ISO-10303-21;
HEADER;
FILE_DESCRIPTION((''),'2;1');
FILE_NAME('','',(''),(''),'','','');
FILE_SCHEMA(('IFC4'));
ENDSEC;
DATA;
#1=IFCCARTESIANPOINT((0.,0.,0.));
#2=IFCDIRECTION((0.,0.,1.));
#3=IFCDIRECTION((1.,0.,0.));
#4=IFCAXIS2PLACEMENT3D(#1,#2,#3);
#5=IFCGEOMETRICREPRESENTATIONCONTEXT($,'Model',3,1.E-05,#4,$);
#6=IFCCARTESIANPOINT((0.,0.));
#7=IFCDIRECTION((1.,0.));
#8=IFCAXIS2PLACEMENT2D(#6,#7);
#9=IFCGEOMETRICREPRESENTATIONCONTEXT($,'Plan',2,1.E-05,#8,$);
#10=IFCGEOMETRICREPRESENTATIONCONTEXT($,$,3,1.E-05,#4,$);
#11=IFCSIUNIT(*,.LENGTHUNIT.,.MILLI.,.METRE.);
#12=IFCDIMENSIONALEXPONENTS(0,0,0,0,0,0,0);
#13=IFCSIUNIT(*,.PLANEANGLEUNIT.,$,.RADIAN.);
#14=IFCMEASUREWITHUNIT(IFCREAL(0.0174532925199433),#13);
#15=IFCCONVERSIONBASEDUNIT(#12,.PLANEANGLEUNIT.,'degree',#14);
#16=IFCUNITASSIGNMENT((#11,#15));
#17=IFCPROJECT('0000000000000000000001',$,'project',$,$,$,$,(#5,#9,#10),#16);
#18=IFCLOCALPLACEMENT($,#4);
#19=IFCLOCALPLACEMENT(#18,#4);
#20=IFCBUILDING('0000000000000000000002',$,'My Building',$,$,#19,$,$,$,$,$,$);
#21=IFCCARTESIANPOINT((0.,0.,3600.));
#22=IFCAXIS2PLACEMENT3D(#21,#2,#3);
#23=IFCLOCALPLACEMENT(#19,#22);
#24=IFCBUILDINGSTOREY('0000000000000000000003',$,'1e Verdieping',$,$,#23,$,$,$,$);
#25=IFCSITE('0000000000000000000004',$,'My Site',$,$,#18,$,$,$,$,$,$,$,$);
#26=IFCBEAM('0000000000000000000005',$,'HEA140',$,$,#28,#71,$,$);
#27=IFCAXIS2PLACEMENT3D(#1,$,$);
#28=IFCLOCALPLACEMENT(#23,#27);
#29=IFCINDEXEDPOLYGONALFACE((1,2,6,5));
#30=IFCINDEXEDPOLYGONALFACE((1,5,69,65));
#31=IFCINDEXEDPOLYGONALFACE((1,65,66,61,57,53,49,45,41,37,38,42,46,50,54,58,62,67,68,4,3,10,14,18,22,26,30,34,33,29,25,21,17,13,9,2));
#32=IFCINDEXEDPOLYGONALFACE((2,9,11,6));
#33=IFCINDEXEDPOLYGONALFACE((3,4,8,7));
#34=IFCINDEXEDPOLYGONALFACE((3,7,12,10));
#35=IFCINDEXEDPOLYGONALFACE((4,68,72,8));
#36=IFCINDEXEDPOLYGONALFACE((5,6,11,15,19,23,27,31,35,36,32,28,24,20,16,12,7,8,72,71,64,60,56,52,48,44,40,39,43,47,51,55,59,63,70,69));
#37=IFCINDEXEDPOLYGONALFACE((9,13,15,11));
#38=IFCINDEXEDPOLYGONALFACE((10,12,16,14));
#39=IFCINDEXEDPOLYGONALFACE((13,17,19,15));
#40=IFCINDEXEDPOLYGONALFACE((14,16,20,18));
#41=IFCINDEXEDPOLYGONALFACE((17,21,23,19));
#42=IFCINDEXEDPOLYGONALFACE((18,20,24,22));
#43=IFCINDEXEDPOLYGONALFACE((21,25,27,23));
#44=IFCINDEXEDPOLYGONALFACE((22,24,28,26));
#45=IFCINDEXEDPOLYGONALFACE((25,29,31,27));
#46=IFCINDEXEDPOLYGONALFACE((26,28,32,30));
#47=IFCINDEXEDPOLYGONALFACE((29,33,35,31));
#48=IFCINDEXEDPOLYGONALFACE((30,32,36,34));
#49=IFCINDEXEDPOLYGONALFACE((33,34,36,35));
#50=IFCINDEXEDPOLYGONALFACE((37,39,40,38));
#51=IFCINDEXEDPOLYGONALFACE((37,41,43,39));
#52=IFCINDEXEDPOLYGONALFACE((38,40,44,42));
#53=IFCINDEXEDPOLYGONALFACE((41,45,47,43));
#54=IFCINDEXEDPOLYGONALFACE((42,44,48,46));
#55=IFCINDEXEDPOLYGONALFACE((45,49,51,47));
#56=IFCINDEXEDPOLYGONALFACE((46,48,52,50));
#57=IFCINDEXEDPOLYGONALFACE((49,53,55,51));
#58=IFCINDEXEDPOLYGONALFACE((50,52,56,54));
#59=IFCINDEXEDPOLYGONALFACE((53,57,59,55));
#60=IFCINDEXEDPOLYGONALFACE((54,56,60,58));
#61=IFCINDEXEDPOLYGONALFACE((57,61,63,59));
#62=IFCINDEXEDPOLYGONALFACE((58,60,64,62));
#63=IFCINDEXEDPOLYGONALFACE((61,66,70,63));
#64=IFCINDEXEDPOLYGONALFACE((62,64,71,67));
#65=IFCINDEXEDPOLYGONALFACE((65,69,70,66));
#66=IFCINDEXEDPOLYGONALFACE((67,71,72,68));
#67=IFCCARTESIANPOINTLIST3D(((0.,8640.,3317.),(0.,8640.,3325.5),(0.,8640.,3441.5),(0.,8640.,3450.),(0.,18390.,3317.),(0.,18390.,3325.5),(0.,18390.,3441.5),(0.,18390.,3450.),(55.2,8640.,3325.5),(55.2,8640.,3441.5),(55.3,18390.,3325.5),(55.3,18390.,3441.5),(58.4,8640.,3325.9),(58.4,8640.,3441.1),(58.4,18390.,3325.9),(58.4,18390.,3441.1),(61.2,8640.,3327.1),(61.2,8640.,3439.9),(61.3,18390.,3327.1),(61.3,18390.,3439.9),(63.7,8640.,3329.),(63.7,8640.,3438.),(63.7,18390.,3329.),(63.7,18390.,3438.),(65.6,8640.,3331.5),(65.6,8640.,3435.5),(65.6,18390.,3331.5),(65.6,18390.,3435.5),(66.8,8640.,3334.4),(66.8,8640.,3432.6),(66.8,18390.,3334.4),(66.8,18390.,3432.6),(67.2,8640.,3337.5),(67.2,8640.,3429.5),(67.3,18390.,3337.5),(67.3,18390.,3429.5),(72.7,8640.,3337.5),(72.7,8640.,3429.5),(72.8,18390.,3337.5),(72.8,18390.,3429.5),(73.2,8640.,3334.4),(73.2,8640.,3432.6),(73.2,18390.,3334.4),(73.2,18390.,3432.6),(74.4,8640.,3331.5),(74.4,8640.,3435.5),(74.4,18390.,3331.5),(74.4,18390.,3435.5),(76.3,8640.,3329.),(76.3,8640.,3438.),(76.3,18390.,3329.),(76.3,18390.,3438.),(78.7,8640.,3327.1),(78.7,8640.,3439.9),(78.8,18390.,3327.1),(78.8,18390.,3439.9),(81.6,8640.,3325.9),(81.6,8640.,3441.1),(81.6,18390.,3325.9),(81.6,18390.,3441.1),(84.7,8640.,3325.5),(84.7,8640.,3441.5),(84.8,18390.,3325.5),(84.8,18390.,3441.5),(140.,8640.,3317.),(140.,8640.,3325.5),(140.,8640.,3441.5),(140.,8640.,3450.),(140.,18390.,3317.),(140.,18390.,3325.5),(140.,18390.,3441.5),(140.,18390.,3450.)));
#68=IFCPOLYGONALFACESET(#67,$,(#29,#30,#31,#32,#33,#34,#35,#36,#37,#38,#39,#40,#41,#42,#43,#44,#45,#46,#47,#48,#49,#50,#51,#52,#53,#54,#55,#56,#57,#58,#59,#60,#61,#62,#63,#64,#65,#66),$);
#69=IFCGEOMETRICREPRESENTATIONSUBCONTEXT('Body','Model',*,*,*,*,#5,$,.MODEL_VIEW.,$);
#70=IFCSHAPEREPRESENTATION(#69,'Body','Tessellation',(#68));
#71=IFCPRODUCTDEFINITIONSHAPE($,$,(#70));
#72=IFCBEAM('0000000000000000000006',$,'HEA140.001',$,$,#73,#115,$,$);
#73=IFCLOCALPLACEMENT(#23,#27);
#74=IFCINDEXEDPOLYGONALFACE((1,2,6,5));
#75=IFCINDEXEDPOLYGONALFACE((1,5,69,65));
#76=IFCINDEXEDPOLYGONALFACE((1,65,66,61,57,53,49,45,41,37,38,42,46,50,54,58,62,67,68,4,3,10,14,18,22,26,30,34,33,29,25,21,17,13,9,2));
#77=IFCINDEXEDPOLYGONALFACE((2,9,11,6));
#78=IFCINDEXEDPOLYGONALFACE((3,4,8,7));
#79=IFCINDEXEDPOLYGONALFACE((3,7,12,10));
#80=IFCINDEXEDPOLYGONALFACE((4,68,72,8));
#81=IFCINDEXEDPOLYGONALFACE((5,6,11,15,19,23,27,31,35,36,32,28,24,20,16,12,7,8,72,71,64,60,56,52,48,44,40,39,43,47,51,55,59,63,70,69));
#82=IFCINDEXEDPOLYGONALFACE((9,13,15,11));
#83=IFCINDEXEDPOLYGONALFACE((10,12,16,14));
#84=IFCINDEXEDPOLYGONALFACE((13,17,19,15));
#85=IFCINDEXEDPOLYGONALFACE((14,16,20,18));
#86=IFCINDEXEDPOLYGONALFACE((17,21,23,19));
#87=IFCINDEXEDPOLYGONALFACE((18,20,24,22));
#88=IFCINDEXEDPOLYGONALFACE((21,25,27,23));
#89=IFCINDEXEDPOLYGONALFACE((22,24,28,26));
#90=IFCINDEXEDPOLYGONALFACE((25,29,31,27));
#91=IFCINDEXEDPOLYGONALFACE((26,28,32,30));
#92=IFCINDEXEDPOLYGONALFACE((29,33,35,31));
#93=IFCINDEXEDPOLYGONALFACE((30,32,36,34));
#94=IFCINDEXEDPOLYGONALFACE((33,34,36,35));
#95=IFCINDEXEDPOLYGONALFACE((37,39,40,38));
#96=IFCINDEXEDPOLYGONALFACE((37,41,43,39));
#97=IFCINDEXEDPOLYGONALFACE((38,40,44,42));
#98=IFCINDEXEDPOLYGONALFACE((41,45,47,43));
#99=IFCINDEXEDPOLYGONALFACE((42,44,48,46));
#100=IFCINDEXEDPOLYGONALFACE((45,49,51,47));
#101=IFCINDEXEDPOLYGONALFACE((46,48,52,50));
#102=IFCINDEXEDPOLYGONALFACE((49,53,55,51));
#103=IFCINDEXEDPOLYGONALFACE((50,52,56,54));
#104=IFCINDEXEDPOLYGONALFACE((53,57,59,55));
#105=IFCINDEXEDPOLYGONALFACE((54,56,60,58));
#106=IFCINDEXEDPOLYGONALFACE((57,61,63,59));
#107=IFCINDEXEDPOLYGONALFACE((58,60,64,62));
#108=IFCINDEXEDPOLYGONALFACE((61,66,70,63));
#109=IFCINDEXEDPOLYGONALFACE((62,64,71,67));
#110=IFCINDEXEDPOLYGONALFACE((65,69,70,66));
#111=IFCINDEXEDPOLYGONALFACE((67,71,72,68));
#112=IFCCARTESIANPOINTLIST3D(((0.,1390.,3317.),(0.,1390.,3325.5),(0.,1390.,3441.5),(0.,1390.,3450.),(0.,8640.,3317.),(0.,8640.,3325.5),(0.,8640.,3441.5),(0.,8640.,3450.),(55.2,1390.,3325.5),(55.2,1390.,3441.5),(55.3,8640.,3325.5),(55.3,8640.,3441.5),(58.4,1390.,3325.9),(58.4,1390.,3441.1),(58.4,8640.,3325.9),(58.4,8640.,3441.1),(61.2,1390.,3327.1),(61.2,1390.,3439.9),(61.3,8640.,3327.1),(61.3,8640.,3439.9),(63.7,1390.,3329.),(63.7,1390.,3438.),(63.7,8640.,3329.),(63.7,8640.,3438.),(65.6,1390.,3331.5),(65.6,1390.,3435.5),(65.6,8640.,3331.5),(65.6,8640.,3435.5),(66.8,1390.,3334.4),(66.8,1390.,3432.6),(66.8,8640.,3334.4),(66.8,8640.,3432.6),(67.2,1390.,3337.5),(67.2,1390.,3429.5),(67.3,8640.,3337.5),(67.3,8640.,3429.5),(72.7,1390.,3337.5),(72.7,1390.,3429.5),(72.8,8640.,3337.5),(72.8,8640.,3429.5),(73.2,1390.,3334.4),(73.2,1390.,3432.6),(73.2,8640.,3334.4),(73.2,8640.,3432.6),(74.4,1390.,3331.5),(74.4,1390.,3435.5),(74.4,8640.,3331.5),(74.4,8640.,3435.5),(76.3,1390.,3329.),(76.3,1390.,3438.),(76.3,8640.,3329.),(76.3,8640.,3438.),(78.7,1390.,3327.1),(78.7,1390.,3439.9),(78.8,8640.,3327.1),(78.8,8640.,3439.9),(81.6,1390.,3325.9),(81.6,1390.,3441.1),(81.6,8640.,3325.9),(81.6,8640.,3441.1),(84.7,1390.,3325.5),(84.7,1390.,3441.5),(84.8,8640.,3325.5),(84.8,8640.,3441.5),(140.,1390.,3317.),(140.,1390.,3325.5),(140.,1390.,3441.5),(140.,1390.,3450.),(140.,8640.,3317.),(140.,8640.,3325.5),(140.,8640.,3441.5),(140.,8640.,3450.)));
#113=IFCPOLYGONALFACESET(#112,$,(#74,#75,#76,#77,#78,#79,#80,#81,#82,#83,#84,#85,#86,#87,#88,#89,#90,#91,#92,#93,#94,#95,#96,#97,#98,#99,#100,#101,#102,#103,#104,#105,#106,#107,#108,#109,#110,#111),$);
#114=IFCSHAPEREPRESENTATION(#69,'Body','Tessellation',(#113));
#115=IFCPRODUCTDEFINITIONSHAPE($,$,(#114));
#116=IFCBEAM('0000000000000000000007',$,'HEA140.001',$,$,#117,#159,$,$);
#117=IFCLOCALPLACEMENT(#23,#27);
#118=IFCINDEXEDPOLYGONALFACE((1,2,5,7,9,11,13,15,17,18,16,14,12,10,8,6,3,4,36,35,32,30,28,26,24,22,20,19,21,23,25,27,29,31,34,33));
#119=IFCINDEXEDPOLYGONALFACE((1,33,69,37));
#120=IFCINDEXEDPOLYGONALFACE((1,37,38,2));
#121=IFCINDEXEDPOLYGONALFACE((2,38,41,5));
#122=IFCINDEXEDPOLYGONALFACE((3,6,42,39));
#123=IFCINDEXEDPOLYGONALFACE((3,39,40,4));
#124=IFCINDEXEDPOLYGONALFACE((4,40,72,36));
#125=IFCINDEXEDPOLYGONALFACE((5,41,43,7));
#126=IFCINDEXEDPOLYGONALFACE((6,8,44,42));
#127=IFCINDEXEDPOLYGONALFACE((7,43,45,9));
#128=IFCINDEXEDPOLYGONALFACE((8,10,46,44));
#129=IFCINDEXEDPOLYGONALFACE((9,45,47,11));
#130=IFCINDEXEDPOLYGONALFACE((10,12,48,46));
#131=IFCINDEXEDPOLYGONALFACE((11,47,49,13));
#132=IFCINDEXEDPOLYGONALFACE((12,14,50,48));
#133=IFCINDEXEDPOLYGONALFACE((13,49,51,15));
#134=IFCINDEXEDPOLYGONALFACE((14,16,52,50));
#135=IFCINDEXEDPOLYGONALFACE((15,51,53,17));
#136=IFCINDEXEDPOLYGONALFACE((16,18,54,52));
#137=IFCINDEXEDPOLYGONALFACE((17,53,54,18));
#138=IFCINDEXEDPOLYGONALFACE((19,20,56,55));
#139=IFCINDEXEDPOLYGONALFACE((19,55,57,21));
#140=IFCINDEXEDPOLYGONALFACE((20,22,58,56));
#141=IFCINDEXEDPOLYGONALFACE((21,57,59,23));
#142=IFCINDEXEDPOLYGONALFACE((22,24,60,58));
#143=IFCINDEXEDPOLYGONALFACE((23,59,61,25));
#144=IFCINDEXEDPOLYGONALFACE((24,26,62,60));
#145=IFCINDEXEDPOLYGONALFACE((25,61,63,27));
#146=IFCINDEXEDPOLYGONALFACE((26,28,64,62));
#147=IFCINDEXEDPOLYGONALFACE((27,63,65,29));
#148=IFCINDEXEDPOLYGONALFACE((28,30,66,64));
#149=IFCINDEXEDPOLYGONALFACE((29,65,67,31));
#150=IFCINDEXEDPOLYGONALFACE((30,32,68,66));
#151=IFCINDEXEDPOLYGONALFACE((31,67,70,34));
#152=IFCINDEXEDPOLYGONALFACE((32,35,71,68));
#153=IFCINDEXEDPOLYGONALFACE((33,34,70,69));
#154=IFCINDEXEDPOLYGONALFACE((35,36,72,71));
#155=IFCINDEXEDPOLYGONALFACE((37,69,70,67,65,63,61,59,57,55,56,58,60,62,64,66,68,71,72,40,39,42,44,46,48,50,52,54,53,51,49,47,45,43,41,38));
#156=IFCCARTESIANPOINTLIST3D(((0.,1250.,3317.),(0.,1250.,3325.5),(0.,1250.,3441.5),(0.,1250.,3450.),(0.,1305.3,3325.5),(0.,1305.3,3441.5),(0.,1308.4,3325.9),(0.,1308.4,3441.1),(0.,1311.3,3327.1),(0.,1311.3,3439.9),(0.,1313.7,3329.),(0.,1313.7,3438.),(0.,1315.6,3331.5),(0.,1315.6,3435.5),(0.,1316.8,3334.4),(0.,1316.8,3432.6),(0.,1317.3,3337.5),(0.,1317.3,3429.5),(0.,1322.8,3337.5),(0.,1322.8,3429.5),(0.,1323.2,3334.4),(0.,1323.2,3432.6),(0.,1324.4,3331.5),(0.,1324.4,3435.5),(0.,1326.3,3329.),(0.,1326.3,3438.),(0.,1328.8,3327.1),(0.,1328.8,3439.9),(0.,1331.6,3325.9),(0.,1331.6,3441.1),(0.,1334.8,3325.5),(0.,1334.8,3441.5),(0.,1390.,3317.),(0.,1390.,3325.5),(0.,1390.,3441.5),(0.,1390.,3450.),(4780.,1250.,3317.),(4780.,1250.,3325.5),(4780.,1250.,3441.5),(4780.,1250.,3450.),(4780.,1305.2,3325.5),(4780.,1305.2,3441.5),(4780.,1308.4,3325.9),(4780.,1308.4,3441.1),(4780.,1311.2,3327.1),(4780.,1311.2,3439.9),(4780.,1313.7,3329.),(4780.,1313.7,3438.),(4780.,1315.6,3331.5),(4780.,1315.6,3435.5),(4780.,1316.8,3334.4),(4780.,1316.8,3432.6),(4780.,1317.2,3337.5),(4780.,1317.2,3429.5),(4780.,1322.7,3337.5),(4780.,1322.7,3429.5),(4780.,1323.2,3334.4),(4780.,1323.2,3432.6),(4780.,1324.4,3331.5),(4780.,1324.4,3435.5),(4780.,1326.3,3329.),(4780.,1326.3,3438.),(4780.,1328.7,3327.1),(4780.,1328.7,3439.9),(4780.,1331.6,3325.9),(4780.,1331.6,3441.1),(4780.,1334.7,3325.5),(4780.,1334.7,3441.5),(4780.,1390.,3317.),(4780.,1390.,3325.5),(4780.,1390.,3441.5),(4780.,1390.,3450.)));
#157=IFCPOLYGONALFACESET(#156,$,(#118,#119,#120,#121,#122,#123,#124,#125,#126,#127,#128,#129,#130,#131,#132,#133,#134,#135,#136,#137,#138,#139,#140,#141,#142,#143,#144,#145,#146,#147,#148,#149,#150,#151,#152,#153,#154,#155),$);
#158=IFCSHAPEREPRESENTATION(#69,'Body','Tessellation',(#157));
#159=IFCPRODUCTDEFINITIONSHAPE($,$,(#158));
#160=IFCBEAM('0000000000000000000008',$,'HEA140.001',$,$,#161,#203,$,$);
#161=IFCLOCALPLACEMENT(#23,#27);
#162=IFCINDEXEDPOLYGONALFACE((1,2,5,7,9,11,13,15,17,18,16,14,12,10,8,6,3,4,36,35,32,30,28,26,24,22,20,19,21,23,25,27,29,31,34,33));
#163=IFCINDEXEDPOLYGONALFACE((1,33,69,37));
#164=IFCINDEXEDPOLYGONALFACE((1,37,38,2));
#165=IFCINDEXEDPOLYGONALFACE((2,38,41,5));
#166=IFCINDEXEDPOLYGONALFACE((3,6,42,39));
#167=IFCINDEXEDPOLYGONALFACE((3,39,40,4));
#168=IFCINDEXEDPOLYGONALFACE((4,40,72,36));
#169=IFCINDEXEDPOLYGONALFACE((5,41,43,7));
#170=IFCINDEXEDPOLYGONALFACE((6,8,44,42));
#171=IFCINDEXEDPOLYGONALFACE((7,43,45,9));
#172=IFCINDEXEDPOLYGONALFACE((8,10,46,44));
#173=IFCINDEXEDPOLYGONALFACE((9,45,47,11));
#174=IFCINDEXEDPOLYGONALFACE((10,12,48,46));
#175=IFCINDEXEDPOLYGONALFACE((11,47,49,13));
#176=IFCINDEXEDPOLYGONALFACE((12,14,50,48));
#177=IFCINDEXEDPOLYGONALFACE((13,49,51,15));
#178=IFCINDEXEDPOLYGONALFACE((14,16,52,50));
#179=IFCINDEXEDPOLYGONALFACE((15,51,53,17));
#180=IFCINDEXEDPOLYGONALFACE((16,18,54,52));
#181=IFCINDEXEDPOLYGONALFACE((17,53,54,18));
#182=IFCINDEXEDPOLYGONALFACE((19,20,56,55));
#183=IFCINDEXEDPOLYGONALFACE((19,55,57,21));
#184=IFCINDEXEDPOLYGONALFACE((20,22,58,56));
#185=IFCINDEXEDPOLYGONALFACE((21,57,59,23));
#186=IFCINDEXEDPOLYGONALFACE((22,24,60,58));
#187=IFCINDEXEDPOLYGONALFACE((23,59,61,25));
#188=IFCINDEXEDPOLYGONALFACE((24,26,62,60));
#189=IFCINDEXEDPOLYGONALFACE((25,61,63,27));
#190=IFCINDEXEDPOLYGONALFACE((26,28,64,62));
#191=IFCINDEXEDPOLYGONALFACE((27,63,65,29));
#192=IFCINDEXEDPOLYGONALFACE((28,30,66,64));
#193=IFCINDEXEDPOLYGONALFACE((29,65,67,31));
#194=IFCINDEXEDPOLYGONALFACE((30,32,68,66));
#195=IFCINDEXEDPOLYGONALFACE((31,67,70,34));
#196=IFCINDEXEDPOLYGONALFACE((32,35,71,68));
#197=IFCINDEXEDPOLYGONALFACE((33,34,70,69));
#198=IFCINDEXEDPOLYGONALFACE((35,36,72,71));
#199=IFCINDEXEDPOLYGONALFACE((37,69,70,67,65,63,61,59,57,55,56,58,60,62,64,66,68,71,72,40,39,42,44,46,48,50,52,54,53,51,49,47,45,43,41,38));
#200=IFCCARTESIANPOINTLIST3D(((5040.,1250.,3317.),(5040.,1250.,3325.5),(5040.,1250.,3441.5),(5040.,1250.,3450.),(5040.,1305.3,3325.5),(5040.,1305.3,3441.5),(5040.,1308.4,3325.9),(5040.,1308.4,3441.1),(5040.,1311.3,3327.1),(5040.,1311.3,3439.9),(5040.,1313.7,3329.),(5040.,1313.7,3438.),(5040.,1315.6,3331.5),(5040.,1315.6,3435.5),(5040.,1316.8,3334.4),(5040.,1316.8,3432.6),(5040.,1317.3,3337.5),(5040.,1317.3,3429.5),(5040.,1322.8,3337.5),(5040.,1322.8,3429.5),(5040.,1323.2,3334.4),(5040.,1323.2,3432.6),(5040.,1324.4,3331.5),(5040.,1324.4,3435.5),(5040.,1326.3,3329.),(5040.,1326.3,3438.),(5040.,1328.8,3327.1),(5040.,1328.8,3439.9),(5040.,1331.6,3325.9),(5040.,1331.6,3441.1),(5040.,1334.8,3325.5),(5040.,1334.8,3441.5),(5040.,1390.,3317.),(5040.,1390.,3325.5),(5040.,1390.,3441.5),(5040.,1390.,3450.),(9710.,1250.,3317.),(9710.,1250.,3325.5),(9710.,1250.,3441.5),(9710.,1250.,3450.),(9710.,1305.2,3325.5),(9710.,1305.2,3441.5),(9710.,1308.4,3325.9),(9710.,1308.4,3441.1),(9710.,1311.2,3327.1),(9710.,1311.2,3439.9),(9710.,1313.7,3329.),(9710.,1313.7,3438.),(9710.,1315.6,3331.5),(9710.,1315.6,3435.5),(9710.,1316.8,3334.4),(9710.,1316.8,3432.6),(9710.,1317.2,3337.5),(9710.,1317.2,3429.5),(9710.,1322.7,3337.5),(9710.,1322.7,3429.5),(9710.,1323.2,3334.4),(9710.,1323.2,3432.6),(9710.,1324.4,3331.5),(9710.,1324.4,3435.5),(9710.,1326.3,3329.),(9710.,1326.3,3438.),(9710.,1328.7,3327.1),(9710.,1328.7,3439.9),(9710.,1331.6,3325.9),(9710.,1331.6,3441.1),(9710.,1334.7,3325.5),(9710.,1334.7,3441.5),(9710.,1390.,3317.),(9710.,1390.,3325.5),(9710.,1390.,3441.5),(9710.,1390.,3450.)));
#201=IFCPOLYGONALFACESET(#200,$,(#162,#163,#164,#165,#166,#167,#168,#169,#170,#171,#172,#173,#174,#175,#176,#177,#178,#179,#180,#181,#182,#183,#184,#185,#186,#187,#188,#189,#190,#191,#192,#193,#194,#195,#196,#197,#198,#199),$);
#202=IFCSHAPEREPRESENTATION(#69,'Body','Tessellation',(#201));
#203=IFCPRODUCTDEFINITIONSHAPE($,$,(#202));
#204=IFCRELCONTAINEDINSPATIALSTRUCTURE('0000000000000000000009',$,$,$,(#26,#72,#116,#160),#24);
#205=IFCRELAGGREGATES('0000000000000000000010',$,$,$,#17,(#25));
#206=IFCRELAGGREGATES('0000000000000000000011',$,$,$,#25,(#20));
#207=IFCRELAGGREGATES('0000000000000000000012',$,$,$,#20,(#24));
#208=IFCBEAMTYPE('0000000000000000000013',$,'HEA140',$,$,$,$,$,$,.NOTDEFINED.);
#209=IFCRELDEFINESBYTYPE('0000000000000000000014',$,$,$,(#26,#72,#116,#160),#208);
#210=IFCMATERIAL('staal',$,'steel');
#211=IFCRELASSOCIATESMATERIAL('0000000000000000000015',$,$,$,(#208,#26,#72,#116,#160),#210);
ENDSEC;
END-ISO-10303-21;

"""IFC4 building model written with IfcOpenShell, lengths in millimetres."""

from ifc_helpers import new_model, entity, si_unit, converted_unit, frame, origin_with_axes, origin_2d_with_axis, place, context, subcontext, project, spatial, i_section, extrude, material, material_profile, profile_set, profile_usage, type_object, element, save


model = new_model("IFC4")

# Units and contexts
model_context = context("Model", 3, precision=1e-05, world=origin_with_axes())
plan_context = context("Plan", 2, precision=1e-05, world=origin_2d_with_axis())
context_of_model = context(None, 3, precision=1e-05, world=origin_with_axes())
body_context = subcontext(model_context, "Body", "Model", "MODEL_VIEW")
ifc_project = project(units=[si_unit("LENGTHUNIT", "METRE", prefix="MILLI"), converted_unit("PLANEANGLEUNIT", "degree", entity("IfcReal", 0.0174532925199433), si_unit("PLANEANGLEUNIT", "RADIAN"), dimensions=[0, 0, 0, 0, 0, 0, 0])], contexts=[model_context, plan_context, context_of_model])

# Site, building, storey
site_placement = place(None, origin_with_axes())
site = spatial("IfcSite", under=ifc_project, at=site_placement, Name="My Site")
building_placement = place(site_placement, origin_with_axes())
building = spatial("IfcBuilding", under=site, at=building_placement, Name="My Building")
storey_placement = place(building_placement, frame((0.0, 0.0, 3600.0), z_axis=(0.0, 0.0, 1.0), x_axis=(1.0, 0.0, 0.0)))
storey = spatial("IfcBuildingStorey", under=building, at=storey_placement, Name="1e Verdieping")

# Shared definitions
ifc_material_1 = material(Name="staal", Category="steel")

# Beams
ifc_material_profile_1 = material_profile(ifc_material_1, i_section(OverallWidth=140.0, OverallDepth=133.0, WebThickness=5.5, FlangeThickness=8.5, FilletRadius=12.0))
ifc_profile_set_1 = profile_set([ifc_material_profile_1], Name="HEA140")
ifc_profile_usage_1 = profile_usage(ifc_profile_set_1)
beam_type_1 = type_object("IfcBeamType", Name="HEA140", PredefinedType="NOTDEFINED", material=ifc_profile_set_1)
beam_1_placement = place(storey_placement, frame((70.0, 18390.0, 3383.5), z_axis=(0.0, -1.0, 0.0), x_axis=(1.0, 0.0, 0.0)))
element("IfcBeam", 1, at=beam_1_placement, inside=storey, type_object=beam_type_1, material=ifc_profile_usage_1, Name="HEA140", context=body_context, shape_type="SweptSolid", body=[
    extrude(i_section(OverallWidth=140.0, OverallDepth=133.0, WebThickness=5.5, FlangeThickness=8.5, FilletRadius=12.0), origin_with_axes(), (0.0, 0.0, 1.0), 9750.0),
])
ifc_profile_usage_2 = profile_usage(ifc_profile_set_1)
beam_2_placement = place(storey_placement, frame((70.0, 8640.0, 3383.5), z_axis=(0.0, -1.0, 0.0), x_axis=(1.0, 0.0, 0.0)))
element("IfcBeam", 2, at=beam_2_placement, inside=storey, type_object=beam_type_1, material=ifc_profile_usage_2, Name="HEA140.001", context=body_context, shape_type="SweptSolid", body=[
    extrude(i_section(OverallWidth=140.0, OverallDepth=133.0, WebThickness=5.5, FlangeThickness=8.5, FilletRadius=12.0), origin_with_axes(), (0.0, 0.0, 1.0), 7250.0),
])
ifc_profile_usage_3 = profile_usage(ifc_profile_set_1)
beam_3_placement = place(storey_placement, frame((0.0, 1320.0, 3383.5), z_axis=(1.0, 0.0, 0.0), x_axis=(0.0, 1.0, 0.0)))
element("IfcBeam", 3, at=beam_3_placement, inside=storey, type_object=beam_type_1, material=ifc_profile_usage_3, Name="HEA140.001", context=body_context, shape_type="SweptSolid", body=[
    extrude(i_section(OverallWidth=140.0, OverallDepth=133.0, WebThickness=5.5, FlangeThickness=8.5, FilletRadius=12.0), origin_with_axes(), (0.0, 0.0, 1.0), 4780.0),
])
ifc_profile_usage_4 = profile_usage(ifc_profile_set_1)
beam_4_placement = place(storey_placement, frame((5040.0, 1320.0, 3383.5), z_axis=(1.0, 0.0, 0.0), x_axis=(0.0, 1.0, 0.0)))
element("IfcBeam", 4, at=beam_4_placement, inside=storey, type_object=beam_type_1, material=ifc_profile_usage_4, Name="HEA140.001", context=body_context, shape_type="SweptSolid", body=[
    extrude(i_section(OverallWidth=140.0, OverallDepth=133.0, WebThickness=5.5, FlangeThickness=8.5, FilletRadius=12.0), origin_with_axes(), (0.0, 0.0, 1.0), 4670.0),
])

save(model, "model.ifc")
